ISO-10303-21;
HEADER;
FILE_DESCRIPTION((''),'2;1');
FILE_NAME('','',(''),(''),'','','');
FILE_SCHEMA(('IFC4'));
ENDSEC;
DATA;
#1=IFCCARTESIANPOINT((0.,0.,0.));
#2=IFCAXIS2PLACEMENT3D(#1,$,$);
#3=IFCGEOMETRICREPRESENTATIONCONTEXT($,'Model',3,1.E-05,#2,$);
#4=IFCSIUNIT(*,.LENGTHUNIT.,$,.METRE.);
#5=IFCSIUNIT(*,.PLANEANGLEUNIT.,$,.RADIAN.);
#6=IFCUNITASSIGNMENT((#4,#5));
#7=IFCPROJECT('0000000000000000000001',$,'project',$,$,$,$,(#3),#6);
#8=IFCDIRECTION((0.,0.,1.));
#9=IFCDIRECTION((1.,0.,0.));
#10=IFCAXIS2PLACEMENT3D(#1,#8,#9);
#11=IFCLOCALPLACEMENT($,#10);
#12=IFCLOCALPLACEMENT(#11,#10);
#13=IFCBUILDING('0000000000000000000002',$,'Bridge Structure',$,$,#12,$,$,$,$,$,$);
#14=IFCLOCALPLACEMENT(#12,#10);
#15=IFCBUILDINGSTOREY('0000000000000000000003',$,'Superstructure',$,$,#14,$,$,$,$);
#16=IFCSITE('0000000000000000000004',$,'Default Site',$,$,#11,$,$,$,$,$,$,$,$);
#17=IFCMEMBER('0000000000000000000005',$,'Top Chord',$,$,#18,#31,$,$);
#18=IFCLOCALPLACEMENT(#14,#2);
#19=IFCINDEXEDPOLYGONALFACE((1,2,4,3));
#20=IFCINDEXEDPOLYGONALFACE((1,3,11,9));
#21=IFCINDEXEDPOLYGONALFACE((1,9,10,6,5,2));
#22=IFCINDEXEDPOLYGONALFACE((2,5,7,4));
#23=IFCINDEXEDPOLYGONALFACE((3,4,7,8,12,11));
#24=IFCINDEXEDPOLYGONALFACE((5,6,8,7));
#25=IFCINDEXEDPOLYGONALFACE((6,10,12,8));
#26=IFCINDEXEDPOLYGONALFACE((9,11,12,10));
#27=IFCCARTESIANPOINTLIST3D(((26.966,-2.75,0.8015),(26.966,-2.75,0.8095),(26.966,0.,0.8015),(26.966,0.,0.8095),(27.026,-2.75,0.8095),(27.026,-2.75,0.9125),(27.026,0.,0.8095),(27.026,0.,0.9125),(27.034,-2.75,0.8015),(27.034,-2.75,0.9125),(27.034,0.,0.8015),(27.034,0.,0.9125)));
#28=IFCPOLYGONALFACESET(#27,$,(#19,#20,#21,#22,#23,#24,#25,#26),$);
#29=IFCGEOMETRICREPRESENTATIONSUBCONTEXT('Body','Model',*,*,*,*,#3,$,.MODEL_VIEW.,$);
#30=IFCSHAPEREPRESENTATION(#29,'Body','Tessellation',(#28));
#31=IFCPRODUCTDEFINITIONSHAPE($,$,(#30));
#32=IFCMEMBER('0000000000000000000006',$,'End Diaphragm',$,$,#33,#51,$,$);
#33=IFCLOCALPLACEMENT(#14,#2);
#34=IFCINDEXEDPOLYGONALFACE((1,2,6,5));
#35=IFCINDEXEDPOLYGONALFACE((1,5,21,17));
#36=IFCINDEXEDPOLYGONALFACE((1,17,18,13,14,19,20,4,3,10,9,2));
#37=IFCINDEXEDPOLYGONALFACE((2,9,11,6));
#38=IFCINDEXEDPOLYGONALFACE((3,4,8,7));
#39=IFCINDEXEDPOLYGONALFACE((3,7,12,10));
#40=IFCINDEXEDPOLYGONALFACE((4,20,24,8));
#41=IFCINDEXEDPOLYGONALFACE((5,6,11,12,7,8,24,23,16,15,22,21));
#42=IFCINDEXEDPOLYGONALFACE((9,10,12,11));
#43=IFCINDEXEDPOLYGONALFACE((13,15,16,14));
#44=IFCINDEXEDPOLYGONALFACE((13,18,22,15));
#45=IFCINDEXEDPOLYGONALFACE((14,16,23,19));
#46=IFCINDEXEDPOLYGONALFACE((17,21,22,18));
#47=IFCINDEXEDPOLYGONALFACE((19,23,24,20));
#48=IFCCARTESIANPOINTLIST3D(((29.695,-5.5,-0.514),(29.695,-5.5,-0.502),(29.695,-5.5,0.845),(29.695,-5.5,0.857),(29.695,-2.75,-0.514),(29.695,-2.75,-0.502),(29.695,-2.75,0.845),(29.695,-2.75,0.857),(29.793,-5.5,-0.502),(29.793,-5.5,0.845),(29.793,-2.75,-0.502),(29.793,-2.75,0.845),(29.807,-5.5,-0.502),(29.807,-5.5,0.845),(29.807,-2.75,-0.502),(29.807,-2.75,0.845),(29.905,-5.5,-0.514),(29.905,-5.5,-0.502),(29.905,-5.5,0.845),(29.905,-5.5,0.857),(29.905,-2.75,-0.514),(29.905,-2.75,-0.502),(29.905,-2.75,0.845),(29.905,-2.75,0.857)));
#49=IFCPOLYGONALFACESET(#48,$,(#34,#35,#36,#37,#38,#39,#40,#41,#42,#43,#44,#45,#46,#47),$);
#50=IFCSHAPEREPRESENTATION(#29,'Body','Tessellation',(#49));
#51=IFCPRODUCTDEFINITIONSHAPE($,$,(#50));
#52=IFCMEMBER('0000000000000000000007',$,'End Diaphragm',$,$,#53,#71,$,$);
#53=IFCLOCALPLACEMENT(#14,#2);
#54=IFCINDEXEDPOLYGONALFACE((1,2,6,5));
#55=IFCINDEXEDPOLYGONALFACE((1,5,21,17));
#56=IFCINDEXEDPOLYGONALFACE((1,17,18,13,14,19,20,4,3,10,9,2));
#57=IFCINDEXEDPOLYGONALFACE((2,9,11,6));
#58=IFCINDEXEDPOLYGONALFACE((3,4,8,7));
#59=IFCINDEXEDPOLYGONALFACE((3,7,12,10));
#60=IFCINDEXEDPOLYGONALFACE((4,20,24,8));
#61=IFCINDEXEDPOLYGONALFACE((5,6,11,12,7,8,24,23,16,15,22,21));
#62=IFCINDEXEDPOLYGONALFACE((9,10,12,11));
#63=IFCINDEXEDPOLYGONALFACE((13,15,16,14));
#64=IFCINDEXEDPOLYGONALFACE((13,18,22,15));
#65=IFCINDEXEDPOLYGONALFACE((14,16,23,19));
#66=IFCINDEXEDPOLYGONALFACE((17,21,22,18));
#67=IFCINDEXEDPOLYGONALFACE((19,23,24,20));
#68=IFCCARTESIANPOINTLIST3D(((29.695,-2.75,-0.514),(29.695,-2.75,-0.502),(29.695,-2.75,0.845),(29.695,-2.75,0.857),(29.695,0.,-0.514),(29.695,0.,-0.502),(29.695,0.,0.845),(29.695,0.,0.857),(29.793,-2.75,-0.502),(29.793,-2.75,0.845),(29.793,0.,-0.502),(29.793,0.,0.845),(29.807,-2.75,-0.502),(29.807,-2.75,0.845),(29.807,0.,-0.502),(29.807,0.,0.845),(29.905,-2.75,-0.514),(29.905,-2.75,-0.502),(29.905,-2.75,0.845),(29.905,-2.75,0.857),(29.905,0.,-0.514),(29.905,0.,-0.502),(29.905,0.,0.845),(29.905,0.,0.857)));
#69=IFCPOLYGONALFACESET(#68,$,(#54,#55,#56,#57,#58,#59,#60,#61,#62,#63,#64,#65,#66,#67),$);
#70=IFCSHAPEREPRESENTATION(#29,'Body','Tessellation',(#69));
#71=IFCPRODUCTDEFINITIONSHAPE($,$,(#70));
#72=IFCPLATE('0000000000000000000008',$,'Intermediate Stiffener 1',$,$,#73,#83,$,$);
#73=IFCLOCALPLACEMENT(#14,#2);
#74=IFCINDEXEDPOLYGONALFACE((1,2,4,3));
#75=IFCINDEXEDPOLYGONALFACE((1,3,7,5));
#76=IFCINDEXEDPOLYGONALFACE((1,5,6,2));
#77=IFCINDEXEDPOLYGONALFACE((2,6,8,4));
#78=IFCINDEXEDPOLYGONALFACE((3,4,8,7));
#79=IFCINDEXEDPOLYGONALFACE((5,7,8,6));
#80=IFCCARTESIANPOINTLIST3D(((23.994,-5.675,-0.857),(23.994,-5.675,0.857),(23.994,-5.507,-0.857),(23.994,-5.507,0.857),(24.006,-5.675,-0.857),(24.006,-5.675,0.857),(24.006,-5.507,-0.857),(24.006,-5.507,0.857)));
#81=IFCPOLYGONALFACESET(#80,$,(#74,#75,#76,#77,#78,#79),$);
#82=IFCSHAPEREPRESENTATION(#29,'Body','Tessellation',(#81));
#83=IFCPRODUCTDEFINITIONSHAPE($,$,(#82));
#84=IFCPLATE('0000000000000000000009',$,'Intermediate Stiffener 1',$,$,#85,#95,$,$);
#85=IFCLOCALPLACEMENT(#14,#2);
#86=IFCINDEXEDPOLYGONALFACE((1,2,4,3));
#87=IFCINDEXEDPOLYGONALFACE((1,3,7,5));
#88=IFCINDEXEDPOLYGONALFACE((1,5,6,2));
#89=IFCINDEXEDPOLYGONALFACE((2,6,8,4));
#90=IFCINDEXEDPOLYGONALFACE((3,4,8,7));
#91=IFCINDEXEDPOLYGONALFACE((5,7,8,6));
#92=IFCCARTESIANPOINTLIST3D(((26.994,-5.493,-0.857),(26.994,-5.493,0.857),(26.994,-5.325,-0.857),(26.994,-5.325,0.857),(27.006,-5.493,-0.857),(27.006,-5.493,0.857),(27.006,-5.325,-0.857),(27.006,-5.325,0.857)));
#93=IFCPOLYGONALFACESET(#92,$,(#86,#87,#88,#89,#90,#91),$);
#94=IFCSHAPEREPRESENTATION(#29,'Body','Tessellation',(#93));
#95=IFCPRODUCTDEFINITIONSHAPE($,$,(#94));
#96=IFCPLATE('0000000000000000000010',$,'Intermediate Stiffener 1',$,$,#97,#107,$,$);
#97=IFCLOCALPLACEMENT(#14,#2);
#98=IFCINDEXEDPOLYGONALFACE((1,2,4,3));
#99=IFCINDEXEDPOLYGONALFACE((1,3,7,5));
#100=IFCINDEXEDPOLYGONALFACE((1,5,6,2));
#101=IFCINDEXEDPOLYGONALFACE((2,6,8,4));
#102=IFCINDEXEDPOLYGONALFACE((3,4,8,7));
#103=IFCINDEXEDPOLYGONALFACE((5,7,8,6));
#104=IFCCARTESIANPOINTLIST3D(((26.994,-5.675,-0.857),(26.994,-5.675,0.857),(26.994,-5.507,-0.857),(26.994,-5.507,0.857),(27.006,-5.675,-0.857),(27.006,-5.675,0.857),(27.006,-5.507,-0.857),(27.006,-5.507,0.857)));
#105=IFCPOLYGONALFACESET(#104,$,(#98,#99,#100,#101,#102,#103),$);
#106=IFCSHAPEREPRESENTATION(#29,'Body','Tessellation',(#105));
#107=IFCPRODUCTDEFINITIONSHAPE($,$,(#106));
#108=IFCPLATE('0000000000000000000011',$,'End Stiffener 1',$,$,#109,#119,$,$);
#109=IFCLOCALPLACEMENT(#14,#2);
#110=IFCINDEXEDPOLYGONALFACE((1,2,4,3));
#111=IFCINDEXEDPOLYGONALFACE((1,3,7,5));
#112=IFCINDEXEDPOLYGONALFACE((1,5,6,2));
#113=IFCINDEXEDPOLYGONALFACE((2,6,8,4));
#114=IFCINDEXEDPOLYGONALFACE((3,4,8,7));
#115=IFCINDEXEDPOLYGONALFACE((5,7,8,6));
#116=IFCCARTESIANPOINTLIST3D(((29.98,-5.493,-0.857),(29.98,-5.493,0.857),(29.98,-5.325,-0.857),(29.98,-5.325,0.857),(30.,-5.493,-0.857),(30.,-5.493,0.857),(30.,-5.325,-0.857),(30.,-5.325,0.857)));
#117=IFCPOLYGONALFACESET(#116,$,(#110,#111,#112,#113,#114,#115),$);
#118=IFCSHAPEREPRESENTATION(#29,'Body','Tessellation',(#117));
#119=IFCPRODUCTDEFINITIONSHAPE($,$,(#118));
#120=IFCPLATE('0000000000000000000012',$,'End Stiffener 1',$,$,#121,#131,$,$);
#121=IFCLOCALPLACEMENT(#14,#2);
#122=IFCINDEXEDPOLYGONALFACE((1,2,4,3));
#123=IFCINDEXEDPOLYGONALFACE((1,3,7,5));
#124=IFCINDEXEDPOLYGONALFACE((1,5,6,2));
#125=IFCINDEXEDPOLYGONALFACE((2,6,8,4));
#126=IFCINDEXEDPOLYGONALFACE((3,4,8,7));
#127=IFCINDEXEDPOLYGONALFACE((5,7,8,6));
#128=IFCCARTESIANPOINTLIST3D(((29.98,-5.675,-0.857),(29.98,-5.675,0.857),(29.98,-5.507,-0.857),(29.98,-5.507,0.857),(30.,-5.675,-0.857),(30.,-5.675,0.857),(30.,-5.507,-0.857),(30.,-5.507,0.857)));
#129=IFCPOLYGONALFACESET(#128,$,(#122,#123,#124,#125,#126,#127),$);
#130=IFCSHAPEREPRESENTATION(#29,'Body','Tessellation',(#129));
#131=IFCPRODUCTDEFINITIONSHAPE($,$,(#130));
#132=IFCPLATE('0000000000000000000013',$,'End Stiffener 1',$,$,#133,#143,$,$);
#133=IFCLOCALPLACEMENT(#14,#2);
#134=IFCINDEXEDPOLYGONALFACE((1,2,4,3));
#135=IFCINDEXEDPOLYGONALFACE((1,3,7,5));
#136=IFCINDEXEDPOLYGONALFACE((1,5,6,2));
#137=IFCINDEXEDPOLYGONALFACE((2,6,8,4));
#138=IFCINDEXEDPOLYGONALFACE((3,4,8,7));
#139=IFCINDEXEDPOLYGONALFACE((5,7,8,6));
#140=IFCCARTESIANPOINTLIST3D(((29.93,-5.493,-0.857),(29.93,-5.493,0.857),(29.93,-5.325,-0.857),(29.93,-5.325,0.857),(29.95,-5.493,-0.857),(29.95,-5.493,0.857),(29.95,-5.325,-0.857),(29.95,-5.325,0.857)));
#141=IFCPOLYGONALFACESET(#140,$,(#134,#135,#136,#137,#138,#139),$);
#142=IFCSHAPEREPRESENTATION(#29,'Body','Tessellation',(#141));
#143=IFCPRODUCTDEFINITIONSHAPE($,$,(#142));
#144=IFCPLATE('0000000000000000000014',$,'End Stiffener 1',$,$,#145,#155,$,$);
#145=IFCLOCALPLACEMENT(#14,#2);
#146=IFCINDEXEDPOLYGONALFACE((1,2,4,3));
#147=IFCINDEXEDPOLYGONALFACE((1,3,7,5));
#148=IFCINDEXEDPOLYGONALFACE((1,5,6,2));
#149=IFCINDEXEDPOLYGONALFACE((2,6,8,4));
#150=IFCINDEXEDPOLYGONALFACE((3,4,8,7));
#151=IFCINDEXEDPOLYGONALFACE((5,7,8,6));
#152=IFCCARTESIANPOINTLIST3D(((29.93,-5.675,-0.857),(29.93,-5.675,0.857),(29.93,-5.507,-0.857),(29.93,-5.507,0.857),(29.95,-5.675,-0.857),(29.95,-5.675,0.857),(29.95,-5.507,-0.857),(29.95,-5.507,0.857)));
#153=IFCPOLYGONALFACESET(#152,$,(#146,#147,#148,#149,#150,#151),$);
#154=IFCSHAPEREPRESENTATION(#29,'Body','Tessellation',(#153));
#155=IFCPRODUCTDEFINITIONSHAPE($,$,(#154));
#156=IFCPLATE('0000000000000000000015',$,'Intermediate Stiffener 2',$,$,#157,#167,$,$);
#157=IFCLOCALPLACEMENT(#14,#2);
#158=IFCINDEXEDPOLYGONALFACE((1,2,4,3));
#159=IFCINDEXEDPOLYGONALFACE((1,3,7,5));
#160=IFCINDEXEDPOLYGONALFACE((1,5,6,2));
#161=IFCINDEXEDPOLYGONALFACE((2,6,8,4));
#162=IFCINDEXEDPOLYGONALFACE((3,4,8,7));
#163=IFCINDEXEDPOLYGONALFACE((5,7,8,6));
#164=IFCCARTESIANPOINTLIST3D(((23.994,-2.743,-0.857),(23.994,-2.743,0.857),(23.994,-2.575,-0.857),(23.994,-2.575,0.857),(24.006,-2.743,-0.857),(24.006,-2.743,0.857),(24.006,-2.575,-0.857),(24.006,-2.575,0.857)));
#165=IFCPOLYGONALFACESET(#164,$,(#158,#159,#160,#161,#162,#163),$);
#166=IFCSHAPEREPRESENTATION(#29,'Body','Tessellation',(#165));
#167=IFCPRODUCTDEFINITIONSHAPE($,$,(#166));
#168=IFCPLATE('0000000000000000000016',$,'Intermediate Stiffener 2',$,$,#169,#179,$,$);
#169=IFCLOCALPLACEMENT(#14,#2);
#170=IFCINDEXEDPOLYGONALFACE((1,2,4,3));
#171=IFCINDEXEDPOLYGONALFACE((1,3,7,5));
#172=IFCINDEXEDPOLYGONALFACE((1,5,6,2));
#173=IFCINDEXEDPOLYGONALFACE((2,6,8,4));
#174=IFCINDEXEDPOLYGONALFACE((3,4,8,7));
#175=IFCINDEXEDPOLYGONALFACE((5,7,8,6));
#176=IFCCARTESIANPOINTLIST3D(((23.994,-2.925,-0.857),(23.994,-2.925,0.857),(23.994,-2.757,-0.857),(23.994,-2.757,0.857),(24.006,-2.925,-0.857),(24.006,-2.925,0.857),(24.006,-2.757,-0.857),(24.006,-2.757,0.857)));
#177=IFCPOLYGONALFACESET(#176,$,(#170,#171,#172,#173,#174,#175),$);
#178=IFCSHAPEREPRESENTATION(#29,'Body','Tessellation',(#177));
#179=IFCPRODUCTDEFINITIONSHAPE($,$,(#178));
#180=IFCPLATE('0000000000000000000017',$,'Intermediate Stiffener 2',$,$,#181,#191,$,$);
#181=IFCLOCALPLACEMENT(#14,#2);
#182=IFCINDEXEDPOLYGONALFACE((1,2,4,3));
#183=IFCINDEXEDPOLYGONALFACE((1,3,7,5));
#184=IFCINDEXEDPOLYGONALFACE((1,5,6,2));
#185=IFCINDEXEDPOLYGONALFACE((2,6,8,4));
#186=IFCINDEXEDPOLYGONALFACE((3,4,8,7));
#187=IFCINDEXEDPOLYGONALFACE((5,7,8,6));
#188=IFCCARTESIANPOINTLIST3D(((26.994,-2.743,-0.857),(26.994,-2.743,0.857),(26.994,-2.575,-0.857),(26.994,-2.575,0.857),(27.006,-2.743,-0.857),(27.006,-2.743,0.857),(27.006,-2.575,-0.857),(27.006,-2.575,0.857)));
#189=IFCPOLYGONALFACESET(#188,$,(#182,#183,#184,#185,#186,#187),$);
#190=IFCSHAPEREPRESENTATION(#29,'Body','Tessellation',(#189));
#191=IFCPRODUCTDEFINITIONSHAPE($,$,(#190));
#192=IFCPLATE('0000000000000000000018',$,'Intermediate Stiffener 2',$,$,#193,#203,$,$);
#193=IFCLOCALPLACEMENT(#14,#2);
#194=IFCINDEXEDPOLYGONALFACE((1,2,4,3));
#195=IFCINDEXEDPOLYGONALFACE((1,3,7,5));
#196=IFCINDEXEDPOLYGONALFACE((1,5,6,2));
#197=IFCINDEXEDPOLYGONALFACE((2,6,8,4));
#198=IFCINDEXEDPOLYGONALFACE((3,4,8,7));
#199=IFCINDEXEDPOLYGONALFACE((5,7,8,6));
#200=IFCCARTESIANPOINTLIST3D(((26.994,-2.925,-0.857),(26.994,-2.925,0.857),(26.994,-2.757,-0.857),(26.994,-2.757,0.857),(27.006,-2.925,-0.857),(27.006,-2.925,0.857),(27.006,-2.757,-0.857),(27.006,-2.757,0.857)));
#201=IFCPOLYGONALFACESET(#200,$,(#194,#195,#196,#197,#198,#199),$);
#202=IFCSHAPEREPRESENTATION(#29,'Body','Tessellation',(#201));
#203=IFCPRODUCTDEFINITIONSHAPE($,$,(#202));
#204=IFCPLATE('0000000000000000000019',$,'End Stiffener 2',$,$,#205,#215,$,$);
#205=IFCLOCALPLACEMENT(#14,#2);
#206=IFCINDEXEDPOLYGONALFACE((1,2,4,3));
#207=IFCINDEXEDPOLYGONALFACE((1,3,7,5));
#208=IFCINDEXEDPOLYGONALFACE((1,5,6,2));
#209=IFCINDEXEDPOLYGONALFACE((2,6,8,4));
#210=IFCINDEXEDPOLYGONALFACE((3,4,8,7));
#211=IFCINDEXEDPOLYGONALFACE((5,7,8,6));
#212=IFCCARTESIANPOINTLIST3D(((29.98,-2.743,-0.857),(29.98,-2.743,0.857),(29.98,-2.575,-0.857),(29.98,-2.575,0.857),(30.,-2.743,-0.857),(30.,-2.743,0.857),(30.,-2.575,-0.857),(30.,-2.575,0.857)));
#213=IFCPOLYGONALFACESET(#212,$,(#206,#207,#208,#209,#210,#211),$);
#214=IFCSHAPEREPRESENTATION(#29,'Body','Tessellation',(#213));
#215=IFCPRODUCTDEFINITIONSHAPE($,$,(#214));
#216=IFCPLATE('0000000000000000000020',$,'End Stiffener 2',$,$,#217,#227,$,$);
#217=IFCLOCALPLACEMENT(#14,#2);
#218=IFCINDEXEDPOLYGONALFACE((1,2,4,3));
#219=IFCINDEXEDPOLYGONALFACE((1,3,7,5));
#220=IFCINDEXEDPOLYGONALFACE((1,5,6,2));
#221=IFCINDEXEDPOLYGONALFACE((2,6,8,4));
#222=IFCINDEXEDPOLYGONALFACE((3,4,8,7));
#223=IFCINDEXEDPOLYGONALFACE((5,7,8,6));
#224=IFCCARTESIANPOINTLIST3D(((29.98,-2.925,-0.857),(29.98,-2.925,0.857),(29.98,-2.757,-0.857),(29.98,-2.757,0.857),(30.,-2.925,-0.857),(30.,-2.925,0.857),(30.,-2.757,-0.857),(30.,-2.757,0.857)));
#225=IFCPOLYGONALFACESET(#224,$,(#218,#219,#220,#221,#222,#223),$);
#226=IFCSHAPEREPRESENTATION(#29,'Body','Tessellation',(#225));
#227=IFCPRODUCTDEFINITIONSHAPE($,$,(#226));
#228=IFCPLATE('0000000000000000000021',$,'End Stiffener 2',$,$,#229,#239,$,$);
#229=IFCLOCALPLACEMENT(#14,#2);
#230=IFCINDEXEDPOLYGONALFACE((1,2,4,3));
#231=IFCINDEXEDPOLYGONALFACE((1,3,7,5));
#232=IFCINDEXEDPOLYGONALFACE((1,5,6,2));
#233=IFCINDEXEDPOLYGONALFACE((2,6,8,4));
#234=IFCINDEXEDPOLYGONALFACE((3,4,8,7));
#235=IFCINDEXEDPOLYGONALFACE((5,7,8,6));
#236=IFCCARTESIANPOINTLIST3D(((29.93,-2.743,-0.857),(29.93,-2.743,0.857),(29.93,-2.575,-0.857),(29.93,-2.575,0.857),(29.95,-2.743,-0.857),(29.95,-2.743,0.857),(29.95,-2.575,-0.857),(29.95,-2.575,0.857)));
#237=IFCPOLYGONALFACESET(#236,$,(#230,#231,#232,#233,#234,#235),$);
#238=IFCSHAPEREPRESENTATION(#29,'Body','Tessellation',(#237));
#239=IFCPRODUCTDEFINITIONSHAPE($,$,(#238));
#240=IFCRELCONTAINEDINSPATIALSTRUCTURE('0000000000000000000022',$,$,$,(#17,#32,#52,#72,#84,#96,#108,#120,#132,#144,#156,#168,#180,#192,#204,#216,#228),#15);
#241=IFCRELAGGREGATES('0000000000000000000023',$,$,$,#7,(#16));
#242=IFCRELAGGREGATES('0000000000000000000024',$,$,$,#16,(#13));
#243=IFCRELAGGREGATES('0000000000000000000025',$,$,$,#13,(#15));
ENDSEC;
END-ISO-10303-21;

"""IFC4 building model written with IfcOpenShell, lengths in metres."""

from ifc_helpers import new_model, si_unit, frame, origin, origin_with_axes, origin_2d_with_axis, place, context, subcontext, project, spatial, rectangle, i_section, l_section, extrude, element, save


model = new_model("IFC4")

# Units and contexts
model_context = context("Model", 3, precision=1e-05, world=origin())
body_context = subcontext(model_context, "Body", "Model", "MODEL_VIEW")
ifc_project = project(units=[si_unit("LENGTHUNIT", "METRE"), si_unit("PLANEANGLEUNIT", "RADIAN")], contexts=[model_context])

# Site, building, storey
site_placement = place(None, origin_with_axes())
site = spatial("IfcSite", under=ifc_project, at=site_placement, Name="Default Site")
building_placement = place(site_placement, origin_with_axes())
building = spatial("IfcBuilding", under=site, at=building_placement, Name="Bridge Structure")
storey_placement = place(building_placement, origin_with_axes())
storey = spatial("IfcBuildingStorey", under=building, at=storey_placement, Name="Superstructure")

# Members
for number, where, z_axis, x_axis, name in (
    (1, (27.0, -2.75, 0.857), (0.0, 1.0, 0.0), (-1.0, 0.0, 0.0), "Top Chord"),
):
    element("IfcMember", number, at=place(storey_placement, frame(where, z_axis=z_axis, x_axis=x_axis)), inside=storey, Name=name, context=body_context, shape_type="SweptSolid", body=[
        extrude(l_section(Depth=0.111, Width=0.068, Thickness=0.008, at=origin_2d_with_axis()), origin_with_axes(), (0.0, 0.0, 1.0), 2.75),
    ])
for number, where, z_axis, x_axis, name in (
    (2, (29.8, -5.5, 0.1715), (0.0, 1.0, 0.0), (-1.0, 0.0, 0.0), "End Diaphragm"),
    (3, (29.8, -2.75, 0.1715), (0.0, 1.0, 0.0), (-1.0, 0.0, 0.0), "End Diaphragm"),
):
    element("IfcMember", number, at=place(storey_placement, frame(where, z_axis=z_axis, x_axis=x_axis)), inside=storey, Name=name, context=body_context, shape_type="SweptSolid", body=[
        extrude(i_section(OverallWidth=0.21, OverallDepth=1.371, WebThickness=0.014, FlangeThickness=0.012, at=origin_2d_with_axis()), origin_with_axes(), (0.0, 0.0, 1.0), 2.75),
    ])

# Plates
for number, where, z_axis, x_axis, name in (
    (4, (24.0, -5.591, -0.857), (0.0, 0.0, 1.0), (1.0, 0.0, 0.0), "Intermediate Stiffener 1"),
    (5, (27.0, -5.409, -0.857), (0.0, 0.0, 1.0), (1.0, 0.0, 0.0), "Intermediate Stiffener 1"),
    (6, (27.0, -5.591, -0.857), (0.0, 0.0, 1.0), (1.0, 0.0, 0.0), "Intermediate Stiffener 1"),
):
    element("IfcPlate", number, at=place(storey_placement, frame(where, z_axis=z_axis, x_axis=x_axis)), inside=storey, Name=name, context=body_context, shape_type="SweptSolid", body=[
        extrude(rectangle(XDim=0.012, YDim=0.168, at=origin_2d_with_axis()), origin_with_axes(), (0.0, 0.0, 1.0), 1.714),
    ])
for number, where, z_axis, x_axis, name in (
    (7, (29.99, -5.409, -0.857), (0.0, 0.0, 1.0), (1.0, 0.0, 0.0), "End Stiffener 1"),
    (8, (29.99, -5.591, -0.857), (0.0, 0.0, 1.0), (1.0, 0.0, 0.0), "End Stiffener 1"),
    (9, (29.94, -5.409, -0.857), (0.0, 0.0, 1.0), (1.0, 0.0, 0.0), "End Stiffener 1"),
    (10, (29.94, -5.591, -0.857), (0.0, 0.0, 1.0), (1.0, 0.0, 0.0), "End Stiffener 1"),
):
    element("IfcPlate", number, at=place(storey_placement, frame(where, z_axis=z_axis, x_axis=x_axis)), inside=storey, Name=name, context=body_context, shape_type="SweptSolid", body=[
        extrude(rectangle(XDim=0.02, YDim=0.168, at=origin_2d_with_axis()), origin_with_axes(), (0.0, 0.0, 1.0), 1.714),
    ])
for number, where, z_axis, x_axis, name in (
    (11, (24.0, -2.659, -0.857), (0.0, 0.0, 1.0), (1.0, 0.0, 0.0), "Intermediate Stiffener 2"),
    (12, (24.0, -2.841, -0.857), (0.0, 0.0, 1.0), (1.0, 0.0, 0.0), "Intermediate Stiffener 2"),
    (13, (27.0, -2.659, -0.857), (0.0, 0.0, 1.0), (1.0, 0.0, 0.0), "Intermediate Stiffener 2"),
    (14, (27.0, -2.841, -0.857), (0.0, 0.0, 1.0), (1.0, 0.0, 0.0), "Intermediate Stiffener 2"),
):
    element("IfcPlate", number, at=place(storey_placement, frame(where, z_axis=z_axis, x_axis=x_axis)), inside=storey, Name=name, context=body_context, shape_type="SweptSolid", body=[
        extrude(rectangle(XDim=0.012, YDim=0.168, at=origin_2d_with_axis()), origin_with_axes(), (0.0, 0.0, 1.0), 1.714),
    ])
for number, where, z_axis, x_axis, name in (
    (15, (29.99, -2.659, -0.857), (0.0, 0.0, 1.0), (1.0, 0.0, 0.0), "End Stiffener 2"),
    (16, (29.99, -2.841, -0.857), (0.0, 0.0, 1.0), (1.0, 0.0, 0.0), "End Stiffener 2"),
    (17, (29.94, -2.659, -0.857), (0.0, 0.0, 1.0), (1.0, 0.0, 0.0), "End Stiffener 2"),
):
    element("IfcPlate", number, at=place(storey_placement, frame(where, z_axis=z_axis, x_axis=x_axis)), inside=storey, Name=name, context=body_context, shape_type="SweptSolid", body=[
        extrude(rectangle(XDim=0.02, YDim=0.168, at=origin_2d_with_axis()), origin_with_axes(), (0.0, 0.0, 1.0), 1.714),
    ])

save(model, "model.ifc")
